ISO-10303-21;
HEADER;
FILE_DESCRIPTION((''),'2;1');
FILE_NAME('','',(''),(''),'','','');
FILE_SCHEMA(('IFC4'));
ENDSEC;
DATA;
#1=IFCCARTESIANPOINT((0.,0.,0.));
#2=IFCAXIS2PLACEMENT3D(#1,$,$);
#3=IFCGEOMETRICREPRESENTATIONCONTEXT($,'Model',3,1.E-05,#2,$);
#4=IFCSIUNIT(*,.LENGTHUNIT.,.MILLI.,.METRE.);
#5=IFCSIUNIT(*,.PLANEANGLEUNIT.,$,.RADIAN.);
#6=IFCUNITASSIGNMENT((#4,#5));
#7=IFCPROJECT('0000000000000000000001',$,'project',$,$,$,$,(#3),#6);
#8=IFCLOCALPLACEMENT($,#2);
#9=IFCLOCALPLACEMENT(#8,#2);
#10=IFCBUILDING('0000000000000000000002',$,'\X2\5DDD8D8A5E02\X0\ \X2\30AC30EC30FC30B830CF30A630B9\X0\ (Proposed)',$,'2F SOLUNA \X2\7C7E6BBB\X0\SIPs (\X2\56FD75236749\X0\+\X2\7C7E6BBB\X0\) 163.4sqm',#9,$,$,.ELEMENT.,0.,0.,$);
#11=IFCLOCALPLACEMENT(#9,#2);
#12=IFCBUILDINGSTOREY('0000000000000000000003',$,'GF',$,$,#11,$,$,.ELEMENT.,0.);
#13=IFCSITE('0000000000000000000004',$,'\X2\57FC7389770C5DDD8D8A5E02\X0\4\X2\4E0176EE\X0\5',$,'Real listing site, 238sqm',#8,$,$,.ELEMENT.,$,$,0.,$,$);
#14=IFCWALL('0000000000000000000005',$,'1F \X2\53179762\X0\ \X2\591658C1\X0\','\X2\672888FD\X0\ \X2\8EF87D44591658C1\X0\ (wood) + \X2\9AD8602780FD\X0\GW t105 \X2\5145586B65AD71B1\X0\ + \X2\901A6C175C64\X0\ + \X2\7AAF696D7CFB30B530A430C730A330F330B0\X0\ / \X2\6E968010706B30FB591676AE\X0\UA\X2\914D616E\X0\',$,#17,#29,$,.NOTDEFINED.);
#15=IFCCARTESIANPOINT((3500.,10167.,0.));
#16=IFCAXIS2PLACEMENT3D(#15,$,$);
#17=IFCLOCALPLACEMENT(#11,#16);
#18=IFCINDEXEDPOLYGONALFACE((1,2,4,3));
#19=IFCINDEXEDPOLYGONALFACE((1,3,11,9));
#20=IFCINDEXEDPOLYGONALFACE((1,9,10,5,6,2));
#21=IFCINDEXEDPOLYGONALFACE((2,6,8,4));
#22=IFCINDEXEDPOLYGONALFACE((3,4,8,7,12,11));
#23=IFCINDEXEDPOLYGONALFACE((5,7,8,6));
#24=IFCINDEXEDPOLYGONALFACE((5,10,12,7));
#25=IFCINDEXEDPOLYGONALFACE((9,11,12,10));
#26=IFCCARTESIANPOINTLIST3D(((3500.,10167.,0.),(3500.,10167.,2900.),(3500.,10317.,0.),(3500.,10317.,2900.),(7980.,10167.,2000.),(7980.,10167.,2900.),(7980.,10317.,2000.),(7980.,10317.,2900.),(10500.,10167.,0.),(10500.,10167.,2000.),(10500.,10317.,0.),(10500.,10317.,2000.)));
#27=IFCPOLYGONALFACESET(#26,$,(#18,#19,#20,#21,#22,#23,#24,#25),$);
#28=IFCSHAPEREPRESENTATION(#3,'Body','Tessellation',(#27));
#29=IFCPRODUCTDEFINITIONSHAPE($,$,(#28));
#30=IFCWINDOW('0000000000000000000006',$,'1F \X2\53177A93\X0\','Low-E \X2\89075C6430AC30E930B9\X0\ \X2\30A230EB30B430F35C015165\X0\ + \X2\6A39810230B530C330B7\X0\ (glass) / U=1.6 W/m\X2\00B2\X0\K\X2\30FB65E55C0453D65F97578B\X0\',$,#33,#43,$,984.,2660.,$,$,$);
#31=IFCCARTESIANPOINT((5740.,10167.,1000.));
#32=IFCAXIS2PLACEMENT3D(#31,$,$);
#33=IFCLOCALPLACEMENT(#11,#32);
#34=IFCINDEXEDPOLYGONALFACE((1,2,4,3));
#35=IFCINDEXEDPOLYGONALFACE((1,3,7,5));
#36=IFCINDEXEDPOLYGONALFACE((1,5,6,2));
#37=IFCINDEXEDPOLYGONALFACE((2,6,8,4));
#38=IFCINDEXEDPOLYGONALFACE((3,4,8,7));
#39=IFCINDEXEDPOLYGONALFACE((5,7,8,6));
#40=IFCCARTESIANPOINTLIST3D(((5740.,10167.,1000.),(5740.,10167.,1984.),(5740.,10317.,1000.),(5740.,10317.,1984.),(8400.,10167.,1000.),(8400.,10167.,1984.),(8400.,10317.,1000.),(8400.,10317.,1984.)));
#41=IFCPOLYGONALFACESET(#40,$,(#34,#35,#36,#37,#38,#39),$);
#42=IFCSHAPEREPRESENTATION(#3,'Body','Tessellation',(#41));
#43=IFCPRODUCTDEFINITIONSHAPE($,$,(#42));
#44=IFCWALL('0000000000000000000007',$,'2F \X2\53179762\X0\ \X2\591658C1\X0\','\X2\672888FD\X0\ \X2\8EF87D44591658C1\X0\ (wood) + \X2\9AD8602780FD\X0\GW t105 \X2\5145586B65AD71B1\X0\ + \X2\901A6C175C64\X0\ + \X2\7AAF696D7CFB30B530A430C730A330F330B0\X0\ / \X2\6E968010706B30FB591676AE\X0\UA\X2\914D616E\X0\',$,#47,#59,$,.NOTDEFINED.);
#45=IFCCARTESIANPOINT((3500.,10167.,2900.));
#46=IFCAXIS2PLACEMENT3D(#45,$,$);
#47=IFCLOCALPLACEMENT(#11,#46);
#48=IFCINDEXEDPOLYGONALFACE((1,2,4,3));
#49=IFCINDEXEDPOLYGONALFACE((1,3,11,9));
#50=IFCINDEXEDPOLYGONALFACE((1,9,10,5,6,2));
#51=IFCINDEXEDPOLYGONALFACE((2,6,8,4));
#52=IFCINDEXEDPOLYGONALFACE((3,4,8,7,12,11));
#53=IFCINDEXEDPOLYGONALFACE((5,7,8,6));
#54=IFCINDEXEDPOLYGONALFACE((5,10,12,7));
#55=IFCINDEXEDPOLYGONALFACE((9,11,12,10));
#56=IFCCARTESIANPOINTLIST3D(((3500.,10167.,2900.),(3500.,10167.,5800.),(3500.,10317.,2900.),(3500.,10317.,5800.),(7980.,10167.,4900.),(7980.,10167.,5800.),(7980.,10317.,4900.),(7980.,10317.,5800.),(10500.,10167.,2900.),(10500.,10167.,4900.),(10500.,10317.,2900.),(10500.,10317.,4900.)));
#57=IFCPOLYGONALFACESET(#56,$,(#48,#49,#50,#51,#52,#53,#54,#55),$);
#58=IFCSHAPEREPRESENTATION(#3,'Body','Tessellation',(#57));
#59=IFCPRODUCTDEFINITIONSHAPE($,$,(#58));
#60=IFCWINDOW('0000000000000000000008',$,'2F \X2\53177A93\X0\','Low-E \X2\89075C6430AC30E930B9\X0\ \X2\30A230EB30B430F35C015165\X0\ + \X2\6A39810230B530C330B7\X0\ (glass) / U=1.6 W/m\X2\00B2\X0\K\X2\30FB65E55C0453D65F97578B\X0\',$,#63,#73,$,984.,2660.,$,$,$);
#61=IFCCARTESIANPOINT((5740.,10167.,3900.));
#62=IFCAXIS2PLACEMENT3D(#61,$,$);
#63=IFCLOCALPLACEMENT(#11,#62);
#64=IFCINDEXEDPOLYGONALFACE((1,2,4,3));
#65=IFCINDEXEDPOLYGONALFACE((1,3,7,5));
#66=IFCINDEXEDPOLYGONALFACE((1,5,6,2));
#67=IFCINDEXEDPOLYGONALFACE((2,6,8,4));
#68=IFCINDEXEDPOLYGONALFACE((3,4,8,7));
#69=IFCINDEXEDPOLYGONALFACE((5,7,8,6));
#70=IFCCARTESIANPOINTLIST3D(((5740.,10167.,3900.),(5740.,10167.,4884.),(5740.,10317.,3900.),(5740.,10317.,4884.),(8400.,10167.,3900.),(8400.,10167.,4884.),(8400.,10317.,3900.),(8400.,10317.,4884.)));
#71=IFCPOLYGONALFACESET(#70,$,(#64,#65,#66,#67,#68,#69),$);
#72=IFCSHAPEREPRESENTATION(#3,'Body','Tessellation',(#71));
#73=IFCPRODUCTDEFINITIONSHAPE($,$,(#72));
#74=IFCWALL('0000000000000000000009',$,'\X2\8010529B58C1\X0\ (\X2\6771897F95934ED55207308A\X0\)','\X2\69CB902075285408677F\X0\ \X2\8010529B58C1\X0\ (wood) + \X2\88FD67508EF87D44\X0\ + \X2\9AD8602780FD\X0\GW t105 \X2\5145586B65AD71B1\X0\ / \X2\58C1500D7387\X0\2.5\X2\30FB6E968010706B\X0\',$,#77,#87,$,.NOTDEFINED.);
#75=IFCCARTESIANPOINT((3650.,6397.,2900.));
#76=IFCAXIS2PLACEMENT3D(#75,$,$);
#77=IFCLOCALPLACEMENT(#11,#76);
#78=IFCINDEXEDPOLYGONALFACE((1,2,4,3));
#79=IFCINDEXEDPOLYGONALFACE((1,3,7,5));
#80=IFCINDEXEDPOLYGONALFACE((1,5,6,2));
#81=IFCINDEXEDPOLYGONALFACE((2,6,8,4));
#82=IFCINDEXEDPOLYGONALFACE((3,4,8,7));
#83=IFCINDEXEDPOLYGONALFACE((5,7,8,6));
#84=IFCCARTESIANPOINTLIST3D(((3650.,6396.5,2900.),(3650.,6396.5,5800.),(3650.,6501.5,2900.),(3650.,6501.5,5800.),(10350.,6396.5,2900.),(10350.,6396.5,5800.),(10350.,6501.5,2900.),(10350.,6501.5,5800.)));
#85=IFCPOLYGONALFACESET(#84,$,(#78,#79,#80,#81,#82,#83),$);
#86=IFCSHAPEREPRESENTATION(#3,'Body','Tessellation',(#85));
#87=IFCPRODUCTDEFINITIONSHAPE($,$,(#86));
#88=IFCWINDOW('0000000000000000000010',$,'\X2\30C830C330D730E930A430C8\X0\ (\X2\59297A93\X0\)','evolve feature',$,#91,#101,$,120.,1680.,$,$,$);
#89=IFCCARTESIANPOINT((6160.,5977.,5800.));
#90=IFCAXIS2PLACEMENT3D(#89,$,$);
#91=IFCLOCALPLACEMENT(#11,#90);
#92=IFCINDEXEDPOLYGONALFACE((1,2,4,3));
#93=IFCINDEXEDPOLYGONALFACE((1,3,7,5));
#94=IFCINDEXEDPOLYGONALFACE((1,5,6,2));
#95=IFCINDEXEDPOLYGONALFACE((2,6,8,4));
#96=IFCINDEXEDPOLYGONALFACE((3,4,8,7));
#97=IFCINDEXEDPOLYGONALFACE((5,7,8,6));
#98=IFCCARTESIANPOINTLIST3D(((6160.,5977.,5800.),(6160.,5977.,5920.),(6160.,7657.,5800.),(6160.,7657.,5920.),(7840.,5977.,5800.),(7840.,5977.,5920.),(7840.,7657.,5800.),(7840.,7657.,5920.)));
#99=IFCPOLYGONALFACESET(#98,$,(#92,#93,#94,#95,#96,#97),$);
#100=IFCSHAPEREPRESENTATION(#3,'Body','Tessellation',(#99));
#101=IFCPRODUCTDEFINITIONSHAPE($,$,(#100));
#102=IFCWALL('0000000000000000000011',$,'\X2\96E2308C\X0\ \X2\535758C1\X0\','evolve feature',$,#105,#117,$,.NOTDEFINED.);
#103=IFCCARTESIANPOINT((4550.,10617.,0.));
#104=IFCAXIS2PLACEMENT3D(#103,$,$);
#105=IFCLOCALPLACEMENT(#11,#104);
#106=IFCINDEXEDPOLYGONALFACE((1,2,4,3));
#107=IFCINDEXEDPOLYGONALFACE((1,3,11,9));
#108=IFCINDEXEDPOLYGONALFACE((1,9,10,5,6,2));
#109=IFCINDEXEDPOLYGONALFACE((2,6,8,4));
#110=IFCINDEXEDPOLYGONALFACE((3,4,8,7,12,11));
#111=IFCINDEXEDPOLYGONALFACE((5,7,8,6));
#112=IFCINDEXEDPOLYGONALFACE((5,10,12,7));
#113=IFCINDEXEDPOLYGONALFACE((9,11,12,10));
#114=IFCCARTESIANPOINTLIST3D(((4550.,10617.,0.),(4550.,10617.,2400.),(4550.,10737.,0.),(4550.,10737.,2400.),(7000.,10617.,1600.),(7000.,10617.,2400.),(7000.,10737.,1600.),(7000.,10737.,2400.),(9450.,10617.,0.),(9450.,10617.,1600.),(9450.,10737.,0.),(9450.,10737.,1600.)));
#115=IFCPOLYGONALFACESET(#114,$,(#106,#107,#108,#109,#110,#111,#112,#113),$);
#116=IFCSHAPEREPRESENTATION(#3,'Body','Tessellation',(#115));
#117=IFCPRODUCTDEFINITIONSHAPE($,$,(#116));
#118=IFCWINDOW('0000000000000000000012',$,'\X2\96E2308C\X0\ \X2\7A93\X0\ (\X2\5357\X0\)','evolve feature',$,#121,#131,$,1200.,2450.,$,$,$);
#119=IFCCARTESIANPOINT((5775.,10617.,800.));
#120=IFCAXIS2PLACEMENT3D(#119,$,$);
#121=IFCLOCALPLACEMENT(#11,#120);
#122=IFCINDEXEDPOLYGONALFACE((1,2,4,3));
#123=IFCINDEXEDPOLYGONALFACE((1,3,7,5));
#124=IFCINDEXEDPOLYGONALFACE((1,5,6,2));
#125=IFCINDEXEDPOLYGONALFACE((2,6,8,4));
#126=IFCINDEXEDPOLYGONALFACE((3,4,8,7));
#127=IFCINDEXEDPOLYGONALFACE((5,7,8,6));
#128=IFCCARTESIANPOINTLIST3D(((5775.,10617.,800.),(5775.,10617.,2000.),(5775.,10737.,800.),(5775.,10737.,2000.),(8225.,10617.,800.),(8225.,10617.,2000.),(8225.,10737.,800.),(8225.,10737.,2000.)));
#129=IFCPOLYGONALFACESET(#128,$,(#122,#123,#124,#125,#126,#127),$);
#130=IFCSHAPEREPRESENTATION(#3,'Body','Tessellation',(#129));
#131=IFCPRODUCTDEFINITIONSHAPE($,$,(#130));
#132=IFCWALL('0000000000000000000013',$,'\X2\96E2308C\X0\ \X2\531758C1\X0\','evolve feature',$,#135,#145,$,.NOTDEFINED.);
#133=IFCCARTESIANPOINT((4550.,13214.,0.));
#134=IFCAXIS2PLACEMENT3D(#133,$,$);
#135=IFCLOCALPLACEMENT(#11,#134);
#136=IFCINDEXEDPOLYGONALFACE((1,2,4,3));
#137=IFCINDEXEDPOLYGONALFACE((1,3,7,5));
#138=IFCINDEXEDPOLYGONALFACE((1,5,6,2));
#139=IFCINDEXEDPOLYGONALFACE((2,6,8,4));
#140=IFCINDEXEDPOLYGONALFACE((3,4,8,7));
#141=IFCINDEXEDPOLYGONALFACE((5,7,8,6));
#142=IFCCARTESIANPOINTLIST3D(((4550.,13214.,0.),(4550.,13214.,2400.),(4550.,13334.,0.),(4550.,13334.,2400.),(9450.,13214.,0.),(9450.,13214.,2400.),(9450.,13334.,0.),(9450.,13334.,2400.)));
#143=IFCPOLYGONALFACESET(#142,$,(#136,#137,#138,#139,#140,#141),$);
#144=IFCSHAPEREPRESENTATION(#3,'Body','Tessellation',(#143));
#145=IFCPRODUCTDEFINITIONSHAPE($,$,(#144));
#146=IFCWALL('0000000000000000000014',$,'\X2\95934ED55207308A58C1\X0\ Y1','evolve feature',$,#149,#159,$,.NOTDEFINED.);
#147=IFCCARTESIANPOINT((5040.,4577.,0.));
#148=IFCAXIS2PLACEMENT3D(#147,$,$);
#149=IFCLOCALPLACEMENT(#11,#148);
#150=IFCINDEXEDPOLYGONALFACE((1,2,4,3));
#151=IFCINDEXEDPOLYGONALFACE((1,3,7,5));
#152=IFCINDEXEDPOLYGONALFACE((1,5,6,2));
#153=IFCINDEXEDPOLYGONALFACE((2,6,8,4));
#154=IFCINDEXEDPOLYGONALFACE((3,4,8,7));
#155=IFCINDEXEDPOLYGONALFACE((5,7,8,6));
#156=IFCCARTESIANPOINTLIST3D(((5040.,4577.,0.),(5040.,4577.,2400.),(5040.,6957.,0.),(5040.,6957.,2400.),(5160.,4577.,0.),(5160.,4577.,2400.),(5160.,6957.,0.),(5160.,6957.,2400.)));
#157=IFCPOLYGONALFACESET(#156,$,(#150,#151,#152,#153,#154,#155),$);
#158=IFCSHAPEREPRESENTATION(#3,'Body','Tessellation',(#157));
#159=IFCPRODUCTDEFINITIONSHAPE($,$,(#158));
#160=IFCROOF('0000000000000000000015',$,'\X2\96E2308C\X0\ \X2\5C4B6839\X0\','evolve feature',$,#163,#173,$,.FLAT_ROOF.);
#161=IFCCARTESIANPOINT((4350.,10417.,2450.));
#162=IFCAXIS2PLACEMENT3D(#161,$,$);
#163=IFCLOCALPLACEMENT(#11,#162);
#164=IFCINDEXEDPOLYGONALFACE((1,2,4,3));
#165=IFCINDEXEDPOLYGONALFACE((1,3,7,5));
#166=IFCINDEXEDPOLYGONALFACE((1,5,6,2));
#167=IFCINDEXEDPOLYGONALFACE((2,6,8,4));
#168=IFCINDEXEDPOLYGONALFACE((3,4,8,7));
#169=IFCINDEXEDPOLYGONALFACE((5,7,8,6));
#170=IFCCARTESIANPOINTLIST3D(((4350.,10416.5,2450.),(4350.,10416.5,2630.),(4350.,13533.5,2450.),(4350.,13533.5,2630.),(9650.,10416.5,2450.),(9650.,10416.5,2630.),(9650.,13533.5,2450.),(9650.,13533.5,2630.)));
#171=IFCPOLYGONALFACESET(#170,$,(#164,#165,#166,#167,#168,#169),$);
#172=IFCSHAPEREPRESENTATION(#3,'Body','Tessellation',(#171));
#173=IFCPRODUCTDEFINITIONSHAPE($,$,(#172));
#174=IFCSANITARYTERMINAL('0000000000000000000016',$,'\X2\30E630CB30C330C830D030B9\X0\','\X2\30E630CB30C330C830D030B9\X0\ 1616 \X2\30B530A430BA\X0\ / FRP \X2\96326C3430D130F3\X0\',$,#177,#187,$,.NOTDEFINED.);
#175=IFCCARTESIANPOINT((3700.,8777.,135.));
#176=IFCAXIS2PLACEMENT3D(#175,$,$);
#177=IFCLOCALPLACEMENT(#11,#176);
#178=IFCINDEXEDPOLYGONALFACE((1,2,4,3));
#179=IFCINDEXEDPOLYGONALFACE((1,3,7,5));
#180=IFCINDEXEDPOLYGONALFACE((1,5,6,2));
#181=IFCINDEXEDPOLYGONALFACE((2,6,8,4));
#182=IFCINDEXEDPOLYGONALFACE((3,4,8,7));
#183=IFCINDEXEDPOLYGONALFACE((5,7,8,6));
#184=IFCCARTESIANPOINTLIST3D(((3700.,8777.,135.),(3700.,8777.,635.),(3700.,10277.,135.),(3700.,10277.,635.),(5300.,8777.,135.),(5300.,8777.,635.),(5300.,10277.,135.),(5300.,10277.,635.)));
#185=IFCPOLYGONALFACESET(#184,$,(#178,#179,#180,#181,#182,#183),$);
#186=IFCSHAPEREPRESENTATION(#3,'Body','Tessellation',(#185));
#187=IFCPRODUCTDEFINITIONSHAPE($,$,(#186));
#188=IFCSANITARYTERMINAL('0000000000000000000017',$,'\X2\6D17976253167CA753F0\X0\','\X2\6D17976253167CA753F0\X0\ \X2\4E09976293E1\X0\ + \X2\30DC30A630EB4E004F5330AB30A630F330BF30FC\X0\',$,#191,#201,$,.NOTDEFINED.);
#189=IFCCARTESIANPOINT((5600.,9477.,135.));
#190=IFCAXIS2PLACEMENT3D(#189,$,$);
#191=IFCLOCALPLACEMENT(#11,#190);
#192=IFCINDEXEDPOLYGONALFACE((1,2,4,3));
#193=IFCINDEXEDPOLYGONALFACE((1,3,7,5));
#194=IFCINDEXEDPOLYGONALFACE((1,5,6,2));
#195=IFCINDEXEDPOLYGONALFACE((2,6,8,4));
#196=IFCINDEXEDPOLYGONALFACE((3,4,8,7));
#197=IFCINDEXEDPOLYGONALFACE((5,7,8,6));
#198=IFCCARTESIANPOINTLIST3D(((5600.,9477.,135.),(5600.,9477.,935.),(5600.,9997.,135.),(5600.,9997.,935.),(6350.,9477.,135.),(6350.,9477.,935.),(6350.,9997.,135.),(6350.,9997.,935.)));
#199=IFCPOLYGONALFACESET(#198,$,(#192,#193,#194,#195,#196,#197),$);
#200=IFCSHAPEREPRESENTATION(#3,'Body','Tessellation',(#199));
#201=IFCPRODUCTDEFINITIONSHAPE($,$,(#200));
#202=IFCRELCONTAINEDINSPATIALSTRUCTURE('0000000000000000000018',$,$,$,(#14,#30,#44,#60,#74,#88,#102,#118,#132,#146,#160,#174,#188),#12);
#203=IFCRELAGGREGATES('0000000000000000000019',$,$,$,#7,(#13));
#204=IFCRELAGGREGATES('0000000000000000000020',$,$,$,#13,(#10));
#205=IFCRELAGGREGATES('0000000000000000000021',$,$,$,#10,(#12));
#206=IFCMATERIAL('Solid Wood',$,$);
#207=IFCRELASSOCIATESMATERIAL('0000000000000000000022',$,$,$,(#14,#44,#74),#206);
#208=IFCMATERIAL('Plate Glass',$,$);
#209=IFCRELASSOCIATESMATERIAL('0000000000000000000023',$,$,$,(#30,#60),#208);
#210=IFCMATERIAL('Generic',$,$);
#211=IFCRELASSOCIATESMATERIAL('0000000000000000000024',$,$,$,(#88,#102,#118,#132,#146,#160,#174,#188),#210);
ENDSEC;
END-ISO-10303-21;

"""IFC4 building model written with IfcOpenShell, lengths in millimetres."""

from ifc_helpers import new_model, si_unit, frame, frame_2d, origin, place, context, project, spatial, rectangle, extrude, material, element, fill, save


model = new_model("IFC4")

# Units and contexts
model_context = context("Model", 3, precision=1e-05, world=origin())
ifc_project = project(units=[si_unit("LENGTHUNIT", "METRE", prefix="MILLI"), si_unit("PLANEANGLEUNIT", "RADIAN")], contexts=[model_context])

# Site, building, storey
site_placement = place(None, origin())
site = spatial("IfcSite", under=ifc_project, at=site_placement, Name="埼玉県川越市4丁目5", ObjectType="Real listing site, 238sqm", CompositionType="ELEMENT", RefElevation=0.0)
building_placement = place(site_placement, origin())
building = spatial("IfcBuilding", under=site, at=building_placement, Name="川越市 ガレージハウス (Proposed)", ObjectType="2F SOLUNA 籾殻SIPs (国産杉+籾殻) 163.4sqm", CompositionType="ELEMENT", ElevationOfRefHeight=0.0, ElevationOfTerrain=0.0)
storey_placement = place(building_placement, origin())
storey = spatial("IfcBuildingStorey", under=building, at=storey_placement, Name="GF", CompositionType="ELEMENT", Elevation=0.0)

# Shared definitions
ifc_material_1 = material(Name="Generic")

# Wall, opening, window
ifc_material_2 = material(Name="Solid Wood")
wall_1_placement = place(storey_placement, frame((3500.0, 10167.0, 0.0)))
wall_1 = element("IfcWall", 1, at=wall_1_placement, inside=storey, material=ifc_material_2, Name="1F 北面 外壁", Description="木製 軸組外壁 (wood) + 高性能GW t105 充填断熱 + 通気層 + 窯業系サイディング / 準耐火・外皮UA配慮", PredefinedType="NOTDEFINED", context=model_context, shape_type="SweptSolid", body=[
    extrude(rectangle(XDim=7000.0, YDim=150.0, at=frame_2d((3500.0, 75.0))), frame((3500.0, 10167.0, 0.0)), (0.0, 0.0, 1.0), 2900.0),
])
opening_1_placement = place(storey_placement, frame((5740.0, 10167.0, 1000.0)))
opening_1 = element("IfcOpeningElement", 2, at=opening_1_placement, cuts=wall_1, PredefinedType="NOTDEFINED", context=model_context, shape_type="SweptSolid", body=[
    extrude(rectangle(XDim=2660.0, YDim=150.0, at=frame_2d((1330.0, 75.0))), frame((5740.0, 10167.0, 1000.0)), (0.0, 0.0, 1.0), 984.0),
])
ifc_material_3 = material(Name="Plate Glass")
window_1_placement = place(storey_placement, frame((5740.0, 10167.0, 1000.0)))
window_1 = element("IfcWindow", 3, at=window_1_placement, inside=storey, material=ifc_material_3, Name="1F 北窓", Description="Low-E 複層ガラス アルゴン封入 + 樹脂サッシ (glass) / U=1.6 W/m²K・日射取得型", OverallHeight=984.0, OverallWidth=2660.0, context=model_context, shape_type="SweptSolid", body=[
    extrude(rectangle(XDim=2660.0, YDim=150.0, at=frame_2d((1330.0, 75.0))), frame((5740.0, 10167.0, 1000.0)), (0.0, 0.0, 1.0), 984.0),
])
fill(opening_1, window_1)

# Wall, opening, window
wall_2_placement = place(storey_placement, frame((3500.0, 10167.0, 2900.0)))
wall_2 = element("IfcWall", 4, at=wall_2_placement, inside=storey, material=ifc_material_2, Name="2F 北面 外壁", Description="木製 軸組外壁 (wood) + 高性能GW t105 充填断熱 + 通気層 + 窯業系サイディング / 準耐火・外皮UA配慮", PredefinedType="NOTDEFINED", context=model_context, shape_type="SweptSolid", body=[
    extrude(rectangle(XDim=7000.0, YDim=150.0, at=frame_2d((3500.0, 75.0))), frame((3500.0, 10167.0, 2900.0)), (0.0, 0.0, 1.0), 2900.0),
])
opening_2_placement = place(storey_placement, frame((5740.0, 10167.0, 3900.0)))
opening_2 = element("IfcOpeningElement", 5, at=opening_2_placement, cuts=wall_2, PredefinedType="NOTDEFINED", context=model_context, shape_type="SweptSolid", body=[
    extrude(rectangle(XDim=2660.0, YDim=150.0, at=frame_2d((1330.0, 75.0))), frame((5740.0, 10167.0, 3900.0)), (0.0, 0.0, 1.0), 984.0),
])
window_2_placement = place(storey_placement, frame((5740.0, 10167.0, 3900.0)))
window_2 = element("IfcWindow", 6, at=window_2_placement, inside=storey, material=ifc_material_3, Name="2F 北窓", Description="Low-E 複層ガラス アルゴン封入 + 樹脂サッシ (glass) / U=1.6 W/m²K・日射取得型", OverallHeight=984.0, OverallWidth=2660.0, context=model_context, shape_type="SweptSolid", body=[
    extrude(rectangle(XDim=2660.0, YDim=150.0, at=frame_2d((1330.0, 75.0))), frame((5740.0, 10167.0, 3900.0)), (0.0, 0.0, 1.0), 984.0),
])
fill(opening_2, window_2)

# Wall
wall_3_placement = place(storey_placement, frame((3650.0, 6397.0, 2900.0)))
element("IfcWall", 7, at=wall_3_placement, inside=storey, material=ifc_material_2, Name="耐力壁 (東西間仕切り)", Description="構造用合板 耐力壁 (wood) + 製材軸組 + 高性能GW t105 充填断熱 / 壁倍率2.5・準耐火", PredefinedType="NOTDEFINED", context=model_context, shape_type="SweptSolid", body=[
    extrude(rectangle(XDim=6700.0, YDim=105.0, at=frame_2d((3350.0, 52.0))), frame((3650.0, 6397.0, 2900.0)), (0.0, 0.0, 1.0), 2900.0),
])

# Window
window_3_placement = place(storey_placement, frame((6160.0, 5977.0, 5800.0)))
element("IfcWindow", 8, at=window_3_placement, inside=storey, material=ifc_material_1, Name="トップライト (天窓)", Description="evolve feature", OverallHeight=120.0, OverallWidth=1680.0, context=model_context, shape_type="SweptSolid", body=[
    extrude(rectangle(XDim=1680.0, YDim=1680.0, at=frame_2d((840.0, 840.0))), frame((6160.0, 5977.0, 5800.0)), (0.0, 0.0, 1.0), 120.0),
])

# Wall, opening, window
wall_4_placement = place(storey_placement, frame((4550.0, 10617.0, 0.0)))
wall_4 = element("IfcWall", 9, at=wall_4_placement, inside=storey, material=ifc_material_1, Name="離れ 南壁", Description="evolve feature", PredefinedType="NOTDEFINED", context=model_context, shape_type="SweptSolid", body=[
    extrude(rectangle(XDim=4900.0, YDim=120.0, at=frame_2d((2450.0, 60.0))), frame((4550.0, 10617.0, 0.0)), (0.0, 0.0, 1.0), 2400.0),
])
opening_3_placement = place(storey_placement, frame((5775.0, 10617.0, 800.0)))
opening_3 = element("IfcOpeningElement", 10, at=opening_3_placement, cuts=wall_4, PredefinedType="NOTDEFINED", context=model_context, shape_type="SweptSolid", body=[
    extrude(rectangle(XDim=2450.0, YDim=120.0, at=frame_2d((1225.0, 60.0))), frame((5775.0, 10617.0, 800.0)), (0.0, 0.0, 1.0), 1200.0),
])
window_4_placement = place(storey_placement, frame((5775.0, 10617.0, 800.0)))
window_4 = element("IfcWindow", 11, at=window_4_placement, inside=storey, material=ifc_material_1, Name="離れ 窓 (南)", Description="evolve feature", OverallHeight=1200.0, OverallWidth=2450.0, context=model_context, shape_type="SweptSolid", body=[
    extrude(rectangle(XDim=2450.0, YDim=120.0, at=frame_2d((1225.0, 60.0))), frame((5775.0, 10617.0, 800.0)), (0.0, 0.0, 1.0), 1200.0),
])
fill(opening_3, window_4)

# Walls
wall_5_placement = place(storey_placement, frame((4550.0, 13214.0, 0.0)))
element("IfcWall", 12, at=wall_5_placement, inside=storey, material=ifc_material_1, Name="離れ 北壁", Description="evolve feature", PredefinedType="NOTDEFINED", context=model_context, shape_type="SweptSolid", body=[
    extrude(rectangle(XDim=4900.0, YDim=120.0, at=frame_2d((2450.0, 60.0))), frame((4550.0, 13214.0, 0.0)), (0.0, 0.0, 1.0), 2400.0),
])
wall_6_placement = place(storey_placement, frame((5040.0, 4577.0, 0.0)))
element("IfcWall", 13, at=wall_6_placement, inside=storey, material=ifc_material_1, Name="間仕切り壁 Y1", Description="evolve feature", PredefinedType="NOTDEFINED", context=model_context, shape_type="SweptSolid", body=[
    extrude(rectangle(XDim=120.0, YDim=2380.0, at=frame_2d((60.0, 1190.0))), frame((5040.0, 4577.0, 0.0)), (0.0, 0.0, 1.0), 2400.0),
])

# Roof
roof_placement = place(storey_placement, frame((4350.0, 10417.0, 2450.0)))
element("IfcRoof", 14, at=roof_placement, inside=storey, material=ifc_material_1, Name="離れ 屋根", Description="evolve feature", PredefinedType="FLAT_ROOF", context=model_context, shape_type="SweptSolid", body=[
    extrude(rectangle(XDim=5300.0, YDim=3117.0, at=frame_2d((2650.0, 1558.0))), frame((4350.0, 10417.0, 2450.0)), (0.0, 0.0, 1.0), 180.0),
])

# Sanitary terminals
sanitary_terminal_1_placement = place(storey_placement, frame((3700.0, 8777.0, 135.0)))
element("IfcSanitaryTerminal", 15, at=sanitary_terminal_1_placement, inside=storey, material=ifc_material_1, Name="ユニットバス", Description="ユニットバス 1616 サイズ / FRP 防水パン", PredefinedType="NOTDEFINED", context=model_context, shape_type="SweptSolid", body=[
    extrude(rectangle(XDim=1600.0, YDim=1500.0, at=frame_2d((800.0, 750.0))), frame((3700.0, 8777.0, 135.0)), (0.0, 0.0, 1.0), 500.0),
])
sanitary_terminal_2_placement = place(storey_placement, frame((5600.0, 9477.0, 135.0)))
element("IfcSanitaryTerminal", 16, at=sanitary_terminal_2_placement, inside=storey, material=ifc_material_1, Name="洗面化粧台", Description="洗面化粧台 三面鏡 + ボウル一体カウンター", PredefinedType="NOTDEFINED", context=model_context, shape_type="SweptSolid", body=[
    extrude(rectangle(XDim=750.0, YDim=520.0, at=frame_2d((375.0, 260.0))), frame((5600.0, 9477.0, 135.0)), (0.0, 0.0, 1.0), 800.0),
])

save(model, "model.ifc")
